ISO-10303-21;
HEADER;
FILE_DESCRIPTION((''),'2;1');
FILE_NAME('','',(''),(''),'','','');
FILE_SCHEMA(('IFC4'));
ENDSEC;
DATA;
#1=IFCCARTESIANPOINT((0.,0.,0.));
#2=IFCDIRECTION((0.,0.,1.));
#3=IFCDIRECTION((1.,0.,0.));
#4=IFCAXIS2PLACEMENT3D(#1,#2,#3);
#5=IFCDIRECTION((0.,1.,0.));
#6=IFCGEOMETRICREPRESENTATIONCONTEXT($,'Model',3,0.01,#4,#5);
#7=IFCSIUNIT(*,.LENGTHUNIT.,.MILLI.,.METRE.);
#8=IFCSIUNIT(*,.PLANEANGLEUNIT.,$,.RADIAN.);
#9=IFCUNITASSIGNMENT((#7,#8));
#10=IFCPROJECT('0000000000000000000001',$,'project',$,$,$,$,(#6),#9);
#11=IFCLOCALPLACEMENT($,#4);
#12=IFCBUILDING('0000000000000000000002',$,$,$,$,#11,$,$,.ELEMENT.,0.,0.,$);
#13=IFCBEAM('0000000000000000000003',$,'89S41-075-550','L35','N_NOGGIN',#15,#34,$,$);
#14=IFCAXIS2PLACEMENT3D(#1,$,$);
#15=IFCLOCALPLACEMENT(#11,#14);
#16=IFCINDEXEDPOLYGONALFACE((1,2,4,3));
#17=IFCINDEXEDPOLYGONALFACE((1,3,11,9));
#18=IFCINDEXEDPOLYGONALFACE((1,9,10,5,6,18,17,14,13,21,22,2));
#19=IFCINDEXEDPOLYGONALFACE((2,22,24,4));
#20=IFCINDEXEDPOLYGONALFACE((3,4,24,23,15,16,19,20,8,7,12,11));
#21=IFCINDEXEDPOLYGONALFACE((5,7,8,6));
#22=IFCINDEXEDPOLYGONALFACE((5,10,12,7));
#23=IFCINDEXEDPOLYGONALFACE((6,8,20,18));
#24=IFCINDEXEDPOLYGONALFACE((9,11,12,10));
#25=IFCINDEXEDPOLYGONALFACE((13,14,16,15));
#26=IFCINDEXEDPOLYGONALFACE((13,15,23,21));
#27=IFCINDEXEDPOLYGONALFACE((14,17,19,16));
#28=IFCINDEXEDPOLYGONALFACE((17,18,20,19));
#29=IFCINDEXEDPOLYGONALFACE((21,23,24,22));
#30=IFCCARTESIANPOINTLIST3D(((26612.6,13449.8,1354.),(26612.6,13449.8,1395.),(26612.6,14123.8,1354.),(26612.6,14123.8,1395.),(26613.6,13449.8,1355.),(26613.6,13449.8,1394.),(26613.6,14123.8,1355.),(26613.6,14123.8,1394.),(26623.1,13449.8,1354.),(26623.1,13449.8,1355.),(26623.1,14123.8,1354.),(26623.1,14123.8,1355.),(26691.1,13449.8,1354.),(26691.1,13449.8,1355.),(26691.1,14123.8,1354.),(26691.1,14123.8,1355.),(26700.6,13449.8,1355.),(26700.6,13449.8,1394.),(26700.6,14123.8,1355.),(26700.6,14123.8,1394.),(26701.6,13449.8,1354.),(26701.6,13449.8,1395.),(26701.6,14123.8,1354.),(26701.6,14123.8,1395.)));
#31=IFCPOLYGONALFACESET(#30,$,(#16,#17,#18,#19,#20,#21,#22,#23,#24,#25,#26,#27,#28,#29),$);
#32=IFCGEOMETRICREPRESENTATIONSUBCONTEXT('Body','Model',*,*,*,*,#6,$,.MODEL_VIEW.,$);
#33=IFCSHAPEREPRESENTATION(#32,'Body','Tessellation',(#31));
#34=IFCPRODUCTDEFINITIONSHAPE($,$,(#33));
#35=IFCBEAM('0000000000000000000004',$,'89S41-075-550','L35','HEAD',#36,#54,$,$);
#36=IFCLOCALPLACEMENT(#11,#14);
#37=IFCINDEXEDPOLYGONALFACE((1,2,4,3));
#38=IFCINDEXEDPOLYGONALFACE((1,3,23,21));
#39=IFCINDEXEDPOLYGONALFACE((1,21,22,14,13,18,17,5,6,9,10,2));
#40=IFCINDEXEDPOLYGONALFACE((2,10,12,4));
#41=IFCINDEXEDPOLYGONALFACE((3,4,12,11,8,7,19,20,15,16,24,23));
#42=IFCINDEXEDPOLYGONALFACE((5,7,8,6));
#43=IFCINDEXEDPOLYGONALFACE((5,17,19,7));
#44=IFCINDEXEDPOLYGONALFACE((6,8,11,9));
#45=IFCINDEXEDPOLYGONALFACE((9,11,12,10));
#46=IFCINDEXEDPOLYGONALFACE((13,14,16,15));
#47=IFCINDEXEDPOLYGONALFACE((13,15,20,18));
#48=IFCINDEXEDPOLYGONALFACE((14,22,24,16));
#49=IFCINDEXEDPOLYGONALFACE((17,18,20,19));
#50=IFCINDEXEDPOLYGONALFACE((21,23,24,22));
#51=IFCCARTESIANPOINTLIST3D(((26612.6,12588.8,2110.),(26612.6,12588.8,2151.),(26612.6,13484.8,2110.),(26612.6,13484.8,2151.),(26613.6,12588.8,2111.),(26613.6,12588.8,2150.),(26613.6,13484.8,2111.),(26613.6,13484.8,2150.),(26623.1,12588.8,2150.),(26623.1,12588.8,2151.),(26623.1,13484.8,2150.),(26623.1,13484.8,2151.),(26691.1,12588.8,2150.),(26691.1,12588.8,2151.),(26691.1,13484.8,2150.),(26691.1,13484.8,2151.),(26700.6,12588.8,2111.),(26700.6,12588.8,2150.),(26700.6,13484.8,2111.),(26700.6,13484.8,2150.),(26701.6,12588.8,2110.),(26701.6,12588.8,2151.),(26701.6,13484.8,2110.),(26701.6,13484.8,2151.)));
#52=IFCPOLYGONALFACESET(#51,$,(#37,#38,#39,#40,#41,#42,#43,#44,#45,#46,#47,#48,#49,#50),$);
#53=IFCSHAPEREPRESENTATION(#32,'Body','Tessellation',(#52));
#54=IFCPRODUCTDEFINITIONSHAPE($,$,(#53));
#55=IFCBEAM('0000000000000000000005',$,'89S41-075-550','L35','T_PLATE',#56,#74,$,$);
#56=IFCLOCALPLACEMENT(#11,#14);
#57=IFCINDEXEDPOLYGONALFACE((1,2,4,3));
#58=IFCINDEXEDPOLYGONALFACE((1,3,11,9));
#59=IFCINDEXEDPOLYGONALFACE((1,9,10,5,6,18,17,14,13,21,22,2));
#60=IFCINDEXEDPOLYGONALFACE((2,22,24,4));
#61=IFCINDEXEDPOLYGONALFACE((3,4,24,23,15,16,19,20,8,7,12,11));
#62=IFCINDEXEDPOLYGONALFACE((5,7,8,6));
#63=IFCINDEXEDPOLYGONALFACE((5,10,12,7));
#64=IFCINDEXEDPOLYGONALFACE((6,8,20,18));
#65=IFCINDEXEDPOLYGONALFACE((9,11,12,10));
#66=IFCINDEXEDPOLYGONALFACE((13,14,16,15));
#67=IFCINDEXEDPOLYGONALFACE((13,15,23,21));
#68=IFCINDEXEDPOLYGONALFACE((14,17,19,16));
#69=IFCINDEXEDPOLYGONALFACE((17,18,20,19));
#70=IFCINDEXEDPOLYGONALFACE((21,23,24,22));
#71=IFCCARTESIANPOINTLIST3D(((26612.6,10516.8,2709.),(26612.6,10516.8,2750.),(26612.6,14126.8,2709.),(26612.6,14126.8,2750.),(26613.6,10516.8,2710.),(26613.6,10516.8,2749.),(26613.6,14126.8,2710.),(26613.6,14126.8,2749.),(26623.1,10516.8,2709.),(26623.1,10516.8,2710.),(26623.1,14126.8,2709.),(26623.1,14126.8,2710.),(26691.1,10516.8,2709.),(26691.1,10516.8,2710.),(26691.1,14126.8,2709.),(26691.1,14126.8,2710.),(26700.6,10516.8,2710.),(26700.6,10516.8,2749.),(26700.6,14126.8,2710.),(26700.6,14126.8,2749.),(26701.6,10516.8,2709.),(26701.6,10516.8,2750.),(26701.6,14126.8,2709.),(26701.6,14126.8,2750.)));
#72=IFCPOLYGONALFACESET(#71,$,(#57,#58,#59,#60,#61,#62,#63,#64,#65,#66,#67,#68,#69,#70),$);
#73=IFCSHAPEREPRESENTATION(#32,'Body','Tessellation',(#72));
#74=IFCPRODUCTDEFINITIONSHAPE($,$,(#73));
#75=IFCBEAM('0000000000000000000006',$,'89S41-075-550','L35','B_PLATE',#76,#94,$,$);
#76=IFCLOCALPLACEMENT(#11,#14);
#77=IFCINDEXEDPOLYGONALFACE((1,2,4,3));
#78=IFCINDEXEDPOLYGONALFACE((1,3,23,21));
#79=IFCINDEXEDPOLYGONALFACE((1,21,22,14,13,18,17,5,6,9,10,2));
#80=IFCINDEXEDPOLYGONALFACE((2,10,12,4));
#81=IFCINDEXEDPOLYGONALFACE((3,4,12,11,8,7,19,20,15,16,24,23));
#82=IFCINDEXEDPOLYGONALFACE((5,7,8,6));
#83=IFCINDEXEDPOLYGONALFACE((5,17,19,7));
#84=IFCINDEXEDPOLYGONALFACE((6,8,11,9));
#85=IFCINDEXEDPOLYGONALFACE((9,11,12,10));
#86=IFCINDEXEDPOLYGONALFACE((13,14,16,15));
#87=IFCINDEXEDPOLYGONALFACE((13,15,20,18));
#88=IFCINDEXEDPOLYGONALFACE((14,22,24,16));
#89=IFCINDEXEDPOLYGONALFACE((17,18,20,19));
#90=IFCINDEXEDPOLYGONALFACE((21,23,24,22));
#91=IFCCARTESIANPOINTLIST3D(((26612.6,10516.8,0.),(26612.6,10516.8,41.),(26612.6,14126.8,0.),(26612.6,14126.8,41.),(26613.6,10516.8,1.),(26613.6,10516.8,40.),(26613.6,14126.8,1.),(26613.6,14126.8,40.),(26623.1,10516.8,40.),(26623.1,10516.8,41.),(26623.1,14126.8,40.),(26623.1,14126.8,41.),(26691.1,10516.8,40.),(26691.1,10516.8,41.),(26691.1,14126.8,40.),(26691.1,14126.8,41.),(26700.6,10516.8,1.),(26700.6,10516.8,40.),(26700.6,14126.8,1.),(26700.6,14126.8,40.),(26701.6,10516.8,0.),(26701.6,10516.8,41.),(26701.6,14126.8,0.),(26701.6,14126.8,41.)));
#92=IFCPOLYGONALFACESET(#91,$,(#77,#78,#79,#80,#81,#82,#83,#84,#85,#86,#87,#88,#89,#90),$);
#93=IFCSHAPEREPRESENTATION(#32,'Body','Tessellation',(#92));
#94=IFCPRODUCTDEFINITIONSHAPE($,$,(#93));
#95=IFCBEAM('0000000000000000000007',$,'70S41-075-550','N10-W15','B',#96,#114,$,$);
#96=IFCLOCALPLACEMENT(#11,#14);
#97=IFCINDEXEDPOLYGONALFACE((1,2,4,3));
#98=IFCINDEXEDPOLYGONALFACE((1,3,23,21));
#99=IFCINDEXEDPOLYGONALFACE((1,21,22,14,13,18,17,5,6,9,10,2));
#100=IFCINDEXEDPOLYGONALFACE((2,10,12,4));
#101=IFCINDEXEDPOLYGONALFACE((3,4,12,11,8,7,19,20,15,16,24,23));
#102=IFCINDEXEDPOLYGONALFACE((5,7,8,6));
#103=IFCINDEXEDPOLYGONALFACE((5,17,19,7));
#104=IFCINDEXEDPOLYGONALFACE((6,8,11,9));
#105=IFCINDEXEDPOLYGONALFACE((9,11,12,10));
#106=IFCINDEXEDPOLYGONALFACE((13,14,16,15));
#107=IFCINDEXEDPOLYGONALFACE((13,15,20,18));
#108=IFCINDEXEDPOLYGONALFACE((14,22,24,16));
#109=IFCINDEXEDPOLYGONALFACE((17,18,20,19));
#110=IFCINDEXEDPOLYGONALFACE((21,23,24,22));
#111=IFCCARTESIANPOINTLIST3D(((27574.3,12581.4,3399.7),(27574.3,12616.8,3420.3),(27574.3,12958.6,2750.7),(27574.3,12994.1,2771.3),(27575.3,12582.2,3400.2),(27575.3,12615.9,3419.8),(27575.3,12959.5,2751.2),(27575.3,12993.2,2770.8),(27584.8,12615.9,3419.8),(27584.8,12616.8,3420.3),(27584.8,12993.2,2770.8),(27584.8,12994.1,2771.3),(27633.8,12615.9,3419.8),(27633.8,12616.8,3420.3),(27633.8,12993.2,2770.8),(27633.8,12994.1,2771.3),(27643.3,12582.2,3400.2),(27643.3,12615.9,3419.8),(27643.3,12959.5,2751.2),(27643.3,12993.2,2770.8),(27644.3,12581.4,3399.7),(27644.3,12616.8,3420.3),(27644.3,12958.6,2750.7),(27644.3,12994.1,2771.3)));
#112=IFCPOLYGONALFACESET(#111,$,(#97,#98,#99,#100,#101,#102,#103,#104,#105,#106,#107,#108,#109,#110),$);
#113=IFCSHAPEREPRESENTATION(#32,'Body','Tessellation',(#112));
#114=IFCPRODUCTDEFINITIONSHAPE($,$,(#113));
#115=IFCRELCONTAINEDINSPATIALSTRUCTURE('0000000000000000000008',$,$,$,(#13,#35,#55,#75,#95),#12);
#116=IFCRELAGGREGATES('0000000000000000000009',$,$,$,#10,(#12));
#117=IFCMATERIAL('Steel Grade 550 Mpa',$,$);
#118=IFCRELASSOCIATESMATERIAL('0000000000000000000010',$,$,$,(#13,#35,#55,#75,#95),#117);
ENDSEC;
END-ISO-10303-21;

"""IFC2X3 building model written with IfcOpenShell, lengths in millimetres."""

from ifc_helpers import new_model, si_unit, direction, frame, origin, origin_with_axes, origin_2d_with_axis, place, context, subcontext, project, spatial, c_section, extrude, source, transform, mapped, material, element, save


model = new_model("IFC2X3")

# Units and contexts
model_context = context("Model", 3, precision=0.01, world=origin_with_axes(), true_north=direction((0.0, 1.0, 0.0)))
body_context = subcontext(model_context, "Body", "Model", "MODEL_VIEW")
ifc_project = project(units=[si_unit("LENGTHUNIT", "METRE", prefix="MILLI"), si_unit("PLANEANGLEUNIT", "RADIAN")], contexts=[model_context])

# Building
building_placement = place(None, origin_with_axes())
building = spatial("IfcBuilding", under=ifc_project, at=building_placement, CompositionType="ELEMENT", ElevationOfRefHeight=0.0, ElevationOfTerrain=0.0)

# Shared definitions
ifc_material = material(Name="Steel Grade 550 Mpa")

# Beams
shared_shape_1 = source(origin(), body_context, "Body", "SweptSolid", [
    extrude(c_section(Depth=89.0, Width=41.0, WallThickness=1.0, Girth=10.5, at=origin_2d_with_axis()), origin_with_axes(), (0.0, 0.0, 1.0), 674.0),
])
beam_1_placement = place(None, frame((26657.1, 14123.8, 1374.5), z_axis=(0.0, -1.0, 0.0), x_axis=(0.0, 0.0, -1.0)))
element("IfcBeam", 1, at=beam_1_placement, inside=building, material=ifc_material, Name="89S41-075-550", Description="L35", ObjectType="N_NOGGIN", context=body_context, shape_type="MappedRepresentation", body=[
    mapped(shared_shape_1, transform((0.0, 0.0, 0.0), scale=1.0)),
])
shared_shape_2 = source(origin(), body_context, "Body", "SweptSolid", [
    extrude(c_section(Depth=89.0, Width=41.0, WallThickness=1.0, Girth=10.5, at=origin_2d_with_axis()), origin_with_axes(), (0.0, 0.0, 1.0), 896.0),
])
beam_2_placement = place(None, frame((26657.1, 13484.8, 2130.5), z_axis=(0.0, -1.0, 0.0), x_axis=(0.0, 0.0, 1.0)))
element("IfcBeam", 2, at=beam_2_placement, inside=building, material=ifc_material, Name="89S41-075-550", Description="L35", ObjectType="HEAD", context=body_context, shape_type="MappedRepresentation", body=[
    mapped(shared_shape_2, transform((0.0, 0.0, 0.0), scale=1.0)),
])
shared_shape_3 = source(origin(), body_context, "Body", "SweptSolid", [
    extrude(c_section(Depth=89.0, Width=41.0, WallThickness=1.0, Girth=10.5, at=origin_2d_with_axis()), origin_with_axes(), (0.0, 0.0, 1.0), 3610.0),
])
beam_3_placement = place(None, frame((26657.1, 14126.8, 2729.5), z_axis=(0.0, -1.0, 0.0), x_axis=(0.0, 0.0, -1.0)))
element("IfcBeam", 3, at=beam_3_placement, inside=building, material=ifc_material, Name="89S41-075-550", Description="L35", ObjectType="T_PLATE", context=body_context, shape_type="MappedRepresentation", body=[
    mapped(shared_shape_3, transform((0.0, 0.0, 0.0), scale=1.0)),
])
shared_shape_4 = source(origin(), body_context, "Body", "SweptSolid", [
    extrude(c_section(Depth=89.0, Width=41.0, WallThickness=1.0, Girth=10.5, at=origin_2d_with_axis()), origin_with_axes(), (0.0, 0.0, 1.0), 3610.0),
])
beam_4_placement = place(None, frame((26657.1, 14126.8, 20.5), z_axis=(0.0, -1.0, 0.0), x_axis=(0.0, 0.0, 1.0)))
element("IfcBeam", 4, at=beam_4_placement, inside=building, material=ifc_material, Name="89S41-075-550", Description="L35", ObjectType="B_PLATE", context=body_context, shape_type="MappedRepresentation", body=[
    mapped(shared_shape_4, transform((0.0, 0.0, 0.0), scale=1.0)),
])
shared_shape_5 = source(origin(), body_context, "Body", "SweptSolid", [
    extrude(c_section(Depth=70.0, Width=41.0, WallThickness=1.0, Girth=10.5, at=origin_2d_with_axis()), origin_with_axes(), (0.0, 0.0, 1.0), 750.7),
])
beam_5_placement = place(None, frame((27609.3, 12976.4, 2761.0), z_axis=(0.0, -0.502577, 0.864533), x_axis=(0.0, 0.864533, 0.502577)))
element("IfcBeam", 5, at=beam_5_placement, inside=building, material=ifc_material, Name="70S41-075-550", Description="N10-W15", ObjectType="B", context=body_context, shape_type="MappedRepresentation", body=[
    mapped(shared_shape_5, transform((0.0, 0.0, 0.0), scale=1.0)),
])

save(model, "model.ifc")
